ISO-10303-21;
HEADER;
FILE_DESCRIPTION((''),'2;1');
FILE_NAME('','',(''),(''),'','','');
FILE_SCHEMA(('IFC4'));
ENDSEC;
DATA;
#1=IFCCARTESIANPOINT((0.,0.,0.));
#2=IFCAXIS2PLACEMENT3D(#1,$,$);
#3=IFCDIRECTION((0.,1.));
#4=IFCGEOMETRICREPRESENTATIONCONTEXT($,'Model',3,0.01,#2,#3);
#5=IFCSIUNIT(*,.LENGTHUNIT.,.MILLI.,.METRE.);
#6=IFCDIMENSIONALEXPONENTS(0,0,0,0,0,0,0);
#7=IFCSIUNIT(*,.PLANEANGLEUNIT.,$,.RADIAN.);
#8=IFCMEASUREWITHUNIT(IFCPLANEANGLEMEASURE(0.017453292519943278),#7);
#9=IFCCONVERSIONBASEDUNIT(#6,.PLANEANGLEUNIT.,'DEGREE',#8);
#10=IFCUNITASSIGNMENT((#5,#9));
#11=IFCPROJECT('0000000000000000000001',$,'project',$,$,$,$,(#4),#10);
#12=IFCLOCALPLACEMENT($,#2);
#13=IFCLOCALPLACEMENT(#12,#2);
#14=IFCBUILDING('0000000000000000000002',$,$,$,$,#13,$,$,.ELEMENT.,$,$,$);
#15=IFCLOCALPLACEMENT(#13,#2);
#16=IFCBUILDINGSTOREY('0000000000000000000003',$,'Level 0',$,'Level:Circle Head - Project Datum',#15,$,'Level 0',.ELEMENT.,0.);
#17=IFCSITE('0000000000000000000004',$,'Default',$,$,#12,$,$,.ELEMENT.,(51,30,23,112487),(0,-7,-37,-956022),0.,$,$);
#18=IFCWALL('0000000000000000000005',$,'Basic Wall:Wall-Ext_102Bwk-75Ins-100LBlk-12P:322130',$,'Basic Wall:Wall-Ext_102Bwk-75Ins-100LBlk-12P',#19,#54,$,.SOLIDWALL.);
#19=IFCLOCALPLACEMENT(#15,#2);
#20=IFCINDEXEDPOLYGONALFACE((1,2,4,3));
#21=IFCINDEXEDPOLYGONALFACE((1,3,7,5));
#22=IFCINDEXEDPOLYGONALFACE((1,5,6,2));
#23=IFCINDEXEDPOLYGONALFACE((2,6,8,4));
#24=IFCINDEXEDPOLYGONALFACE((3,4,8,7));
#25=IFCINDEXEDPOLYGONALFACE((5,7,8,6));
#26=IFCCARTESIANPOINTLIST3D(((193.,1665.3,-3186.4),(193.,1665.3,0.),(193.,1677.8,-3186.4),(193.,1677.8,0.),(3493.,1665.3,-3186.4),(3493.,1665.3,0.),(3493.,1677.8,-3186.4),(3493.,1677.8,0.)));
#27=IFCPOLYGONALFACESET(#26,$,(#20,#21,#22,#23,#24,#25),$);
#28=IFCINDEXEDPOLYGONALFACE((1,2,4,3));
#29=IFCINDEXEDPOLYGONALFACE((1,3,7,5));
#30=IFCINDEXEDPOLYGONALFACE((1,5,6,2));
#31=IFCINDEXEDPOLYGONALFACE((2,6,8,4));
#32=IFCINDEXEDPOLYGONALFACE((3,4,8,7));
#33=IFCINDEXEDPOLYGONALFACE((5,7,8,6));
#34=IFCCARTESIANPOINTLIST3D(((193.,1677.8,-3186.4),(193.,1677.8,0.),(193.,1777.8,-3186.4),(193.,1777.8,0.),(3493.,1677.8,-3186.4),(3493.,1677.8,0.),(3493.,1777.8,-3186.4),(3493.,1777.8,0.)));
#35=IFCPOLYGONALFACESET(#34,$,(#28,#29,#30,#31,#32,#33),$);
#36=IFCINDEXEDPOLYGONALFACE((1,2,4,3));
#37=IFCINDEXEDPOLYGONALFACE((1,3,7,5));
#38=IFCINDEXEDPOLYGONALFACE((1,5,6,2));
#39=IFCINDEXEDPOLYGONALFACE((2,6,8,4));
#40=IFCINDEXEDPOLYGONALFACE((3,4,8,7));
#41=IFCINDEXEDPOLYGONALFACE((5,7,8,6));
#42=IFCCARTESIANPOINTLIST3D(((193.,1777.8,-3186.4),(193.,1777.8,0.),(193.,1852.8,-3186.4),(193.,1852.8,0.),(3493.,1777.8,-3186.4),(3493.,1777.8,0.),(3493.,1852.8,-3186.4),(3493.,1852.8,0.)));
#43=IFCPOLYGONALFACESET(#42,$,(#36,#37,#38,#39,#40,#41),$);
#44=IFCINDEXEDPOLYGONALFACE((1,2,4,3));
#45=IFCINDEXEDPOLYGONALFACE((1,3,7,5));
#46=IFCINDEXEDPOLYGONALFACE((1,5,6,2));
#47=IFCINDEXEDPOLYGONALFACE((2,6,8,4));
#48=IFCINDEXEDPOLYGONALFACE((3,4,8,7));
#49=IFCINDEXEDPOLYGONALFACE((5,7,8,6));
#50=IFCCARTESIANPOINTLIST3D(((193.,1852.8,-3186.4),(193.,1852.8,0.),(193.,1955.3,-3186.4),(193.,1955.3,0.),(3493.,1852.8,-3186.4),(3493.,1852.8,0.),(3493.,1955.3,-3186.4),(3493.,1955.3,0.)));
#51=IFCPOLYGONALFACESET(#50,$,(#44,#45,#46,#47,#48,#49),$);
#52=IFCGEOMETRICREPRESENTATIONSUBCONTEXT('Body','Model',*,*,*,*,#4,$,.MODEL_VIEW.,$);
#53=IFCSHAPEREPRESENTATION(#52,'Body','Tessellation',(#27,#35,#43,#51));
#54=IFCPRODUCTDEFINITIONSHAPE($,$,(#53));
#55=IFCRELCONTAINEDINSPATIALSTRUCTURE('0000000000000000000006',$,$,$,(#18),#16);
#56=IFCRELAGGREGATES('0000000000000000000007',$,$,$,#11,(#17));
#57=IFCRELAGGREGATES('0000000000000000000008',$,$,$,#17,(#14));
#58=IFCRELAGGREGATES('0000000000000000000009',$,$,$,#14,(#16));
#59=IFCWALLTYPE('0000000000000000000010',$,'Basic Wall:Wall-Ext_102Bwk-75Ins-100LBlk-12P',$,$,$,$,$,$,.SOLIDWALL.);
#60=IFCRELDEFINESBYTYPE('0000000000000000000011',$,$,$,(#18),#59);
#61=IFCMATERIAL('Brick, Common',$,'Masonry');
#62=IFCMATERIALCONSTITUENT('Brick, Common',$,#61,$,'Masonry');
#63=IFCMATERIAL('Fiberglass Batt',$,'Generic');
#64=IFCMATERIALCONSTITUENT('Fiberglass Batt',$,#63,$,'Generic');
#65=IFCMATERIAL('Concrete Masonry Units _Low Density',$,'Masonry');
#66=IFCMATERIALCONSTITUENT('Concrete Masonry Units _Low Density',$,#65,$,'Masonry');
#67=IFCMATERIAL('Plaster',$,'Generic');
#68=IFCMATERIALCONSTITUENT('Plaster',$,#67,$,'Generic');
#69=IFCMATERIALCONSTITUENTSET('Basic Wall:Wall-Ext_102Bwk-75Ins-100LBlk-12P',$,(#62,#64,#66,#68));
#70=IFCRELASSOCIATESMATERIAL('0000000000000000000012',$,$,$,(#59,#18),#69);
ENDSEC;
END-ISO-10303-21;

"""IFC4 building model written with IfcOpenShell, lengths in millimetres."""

from ifc_helpers import new_model, entity, si_unit, converted_unit, direction, frame, origin, place, context, subcontext, project, spatial, indexed_curve, outline, extrude, material, constituent, constituent_set, type_object, element, save


model = new_model("IFC4")

# Units and contexts
model_context = context("Model", 3, precision=0.01, world=origin(), true_north=direction((0.0, 1.0)))
body_context = subcontext(model_context, "Body", "Model", "MODEL_VIEW")
ifc_project = project(units=[si_unit("LENGTHUNIT", "METRE", prefix="MILLI"), converted_unit("PLANEANGLEUNIT", "DEGREE", entity("IfcPlaneAngleMeasure", 0.017453292519943278), si_unit("PLANEANGLEUNIT", "RADIAN"), dimensions=[0, 0, 0, 0, 0, 0, 0])], contexts=[model_context])

# Site, building, storey
site_placement = place(None, origin())
site = spatial("IfcSite", under=ifc_project, at=site_placement, Name="Default", CompositionType="ELEMENT", RefLatitude=(51, 30, 23, 112487), RefLongitude=(0, -7, -37, -956022), RefElevation=0.0)
building_placement = place(site_placement, origin())
building = spatial("IfcBuilding", under=site, at=building_placement, CompositionType="ELEMENT")
storey_placement = place(building_placement, origin())
storey = spatial("IfcBuildingStorey", under=building, at=storey_placement, Name="Level 0", ObjectType="Level:Circle Head - Project Datum", LongName="Level 0", CompositionType="ELEMENT", Elevation=0.0)

# Wall
ifc_material_1 = material(Name="Brick, Common", Category="Masonry")
ifc_material_2 = material(Name="Fiberglass Batt", Category="Generic")
ifc_material_3 = material(Name="Concrete Masonry Units _Low Density", Category="Masonry")
ifc_material_4 = material(Name="Plaster", Category="Generic")
ifc_constituent_1 = constituent(ifc_material_1, Name="Brick, Common", Category="Masonry")
ifc_constituent_2 = constituent(ifc_material_2, Name="Fiberglass Batt", Category="Generic")
ifc_constituent_3 = constituent(ifc_material_3, Name="Concrete Masonry Units _Low Density", Category="Masonry")
ifc_constituent_4 = constituent(ifc_material_4, Name="Plaster", Category="Generic")
ifc_constituent_set_1 = constituent_set(constituents=[ifc_constituent_1, ifc_constituent_2, ifc_constituent_3, ifc_constituent_4], Name="Basic Wall:Wall-Ext_102Bwk-75Ins-100LBlk-12P")
wall_type_1 = type_object("IfcWallType", Name="Basic Wall:Wall-Ext_102Bwk-75Ins-100LBlk-12P", PredefinedType="SOLIDWALL", material=ifc_constituent_set_1)
wall_1_placement = place(storey_placement, frame((193.0, 1810.3, -3186.4)))
element("IfcWall", 1, at=wall_1_placement, inside=storey, type_object=wall_type_1, material=ifc_constituent_set_1, Name="Basic Wall:Wall-Ext_102Bwk-75Ins-100LBlk-12P:322130", ObjectType="Basic Wall:Wall-Ext_102Bwk-75Ins-100LBlk-12P", PredefinedType="SOLIDWALL", context=body_context, shape_type="SweptSolid", body=[
    extrude(outline(indexed_curve([(-6.3, -1650.0), (6.2, -1650.0), (6.3, 1650.0), (-6.2, 1650.0), (-6.3, -1650.0)], self_intersect=False)), frame((1650.0, -138.7, 0.0), z_axis=(0.0, 0.0, 1.0), x_axis=(0.0, 1.0, 0.0)), (0.0, 0.0, 1.0), 3186.4),
    extrude(outline(indexed_curve([(-1650.0, -50.0), (1650.0, -50.0), (1650.0, 50.0), (-1650.0, 50.0), (-1650.0, -50.0)], self_intersect=False)), frame((1650.0, -82.5, 0.0)), (0.0, 0.0, 1.0), 3186.4),
    extrude(outline(indexed_curve([(-1650.0, -37.5), (1650.0, -37.5), (1650.0, 37.5), (-1650.0, 37.5), (-1650.0, -37.5)], self_intersect=False)), frame((1650.0, 5.0, 0.0)), (0.0, 0.0, 1.0), 3186.4),
    extrude(outline(indexed_curve([(-51.2, -1650.0), (51.3, -1650.0), (51.2, 1650.0), (-51.3, 1650.0), (-51.2, -1650.0)], self_intersect=False)), frame((1650.0, 93.8, 0.0), z_axis=(0.0, 0.0, 1.0), x_axis=(0.0, -1.0, 0.0)), (0.0, 0.0, 1.0), 3186.4),
])

save(model, "model.ifc")
